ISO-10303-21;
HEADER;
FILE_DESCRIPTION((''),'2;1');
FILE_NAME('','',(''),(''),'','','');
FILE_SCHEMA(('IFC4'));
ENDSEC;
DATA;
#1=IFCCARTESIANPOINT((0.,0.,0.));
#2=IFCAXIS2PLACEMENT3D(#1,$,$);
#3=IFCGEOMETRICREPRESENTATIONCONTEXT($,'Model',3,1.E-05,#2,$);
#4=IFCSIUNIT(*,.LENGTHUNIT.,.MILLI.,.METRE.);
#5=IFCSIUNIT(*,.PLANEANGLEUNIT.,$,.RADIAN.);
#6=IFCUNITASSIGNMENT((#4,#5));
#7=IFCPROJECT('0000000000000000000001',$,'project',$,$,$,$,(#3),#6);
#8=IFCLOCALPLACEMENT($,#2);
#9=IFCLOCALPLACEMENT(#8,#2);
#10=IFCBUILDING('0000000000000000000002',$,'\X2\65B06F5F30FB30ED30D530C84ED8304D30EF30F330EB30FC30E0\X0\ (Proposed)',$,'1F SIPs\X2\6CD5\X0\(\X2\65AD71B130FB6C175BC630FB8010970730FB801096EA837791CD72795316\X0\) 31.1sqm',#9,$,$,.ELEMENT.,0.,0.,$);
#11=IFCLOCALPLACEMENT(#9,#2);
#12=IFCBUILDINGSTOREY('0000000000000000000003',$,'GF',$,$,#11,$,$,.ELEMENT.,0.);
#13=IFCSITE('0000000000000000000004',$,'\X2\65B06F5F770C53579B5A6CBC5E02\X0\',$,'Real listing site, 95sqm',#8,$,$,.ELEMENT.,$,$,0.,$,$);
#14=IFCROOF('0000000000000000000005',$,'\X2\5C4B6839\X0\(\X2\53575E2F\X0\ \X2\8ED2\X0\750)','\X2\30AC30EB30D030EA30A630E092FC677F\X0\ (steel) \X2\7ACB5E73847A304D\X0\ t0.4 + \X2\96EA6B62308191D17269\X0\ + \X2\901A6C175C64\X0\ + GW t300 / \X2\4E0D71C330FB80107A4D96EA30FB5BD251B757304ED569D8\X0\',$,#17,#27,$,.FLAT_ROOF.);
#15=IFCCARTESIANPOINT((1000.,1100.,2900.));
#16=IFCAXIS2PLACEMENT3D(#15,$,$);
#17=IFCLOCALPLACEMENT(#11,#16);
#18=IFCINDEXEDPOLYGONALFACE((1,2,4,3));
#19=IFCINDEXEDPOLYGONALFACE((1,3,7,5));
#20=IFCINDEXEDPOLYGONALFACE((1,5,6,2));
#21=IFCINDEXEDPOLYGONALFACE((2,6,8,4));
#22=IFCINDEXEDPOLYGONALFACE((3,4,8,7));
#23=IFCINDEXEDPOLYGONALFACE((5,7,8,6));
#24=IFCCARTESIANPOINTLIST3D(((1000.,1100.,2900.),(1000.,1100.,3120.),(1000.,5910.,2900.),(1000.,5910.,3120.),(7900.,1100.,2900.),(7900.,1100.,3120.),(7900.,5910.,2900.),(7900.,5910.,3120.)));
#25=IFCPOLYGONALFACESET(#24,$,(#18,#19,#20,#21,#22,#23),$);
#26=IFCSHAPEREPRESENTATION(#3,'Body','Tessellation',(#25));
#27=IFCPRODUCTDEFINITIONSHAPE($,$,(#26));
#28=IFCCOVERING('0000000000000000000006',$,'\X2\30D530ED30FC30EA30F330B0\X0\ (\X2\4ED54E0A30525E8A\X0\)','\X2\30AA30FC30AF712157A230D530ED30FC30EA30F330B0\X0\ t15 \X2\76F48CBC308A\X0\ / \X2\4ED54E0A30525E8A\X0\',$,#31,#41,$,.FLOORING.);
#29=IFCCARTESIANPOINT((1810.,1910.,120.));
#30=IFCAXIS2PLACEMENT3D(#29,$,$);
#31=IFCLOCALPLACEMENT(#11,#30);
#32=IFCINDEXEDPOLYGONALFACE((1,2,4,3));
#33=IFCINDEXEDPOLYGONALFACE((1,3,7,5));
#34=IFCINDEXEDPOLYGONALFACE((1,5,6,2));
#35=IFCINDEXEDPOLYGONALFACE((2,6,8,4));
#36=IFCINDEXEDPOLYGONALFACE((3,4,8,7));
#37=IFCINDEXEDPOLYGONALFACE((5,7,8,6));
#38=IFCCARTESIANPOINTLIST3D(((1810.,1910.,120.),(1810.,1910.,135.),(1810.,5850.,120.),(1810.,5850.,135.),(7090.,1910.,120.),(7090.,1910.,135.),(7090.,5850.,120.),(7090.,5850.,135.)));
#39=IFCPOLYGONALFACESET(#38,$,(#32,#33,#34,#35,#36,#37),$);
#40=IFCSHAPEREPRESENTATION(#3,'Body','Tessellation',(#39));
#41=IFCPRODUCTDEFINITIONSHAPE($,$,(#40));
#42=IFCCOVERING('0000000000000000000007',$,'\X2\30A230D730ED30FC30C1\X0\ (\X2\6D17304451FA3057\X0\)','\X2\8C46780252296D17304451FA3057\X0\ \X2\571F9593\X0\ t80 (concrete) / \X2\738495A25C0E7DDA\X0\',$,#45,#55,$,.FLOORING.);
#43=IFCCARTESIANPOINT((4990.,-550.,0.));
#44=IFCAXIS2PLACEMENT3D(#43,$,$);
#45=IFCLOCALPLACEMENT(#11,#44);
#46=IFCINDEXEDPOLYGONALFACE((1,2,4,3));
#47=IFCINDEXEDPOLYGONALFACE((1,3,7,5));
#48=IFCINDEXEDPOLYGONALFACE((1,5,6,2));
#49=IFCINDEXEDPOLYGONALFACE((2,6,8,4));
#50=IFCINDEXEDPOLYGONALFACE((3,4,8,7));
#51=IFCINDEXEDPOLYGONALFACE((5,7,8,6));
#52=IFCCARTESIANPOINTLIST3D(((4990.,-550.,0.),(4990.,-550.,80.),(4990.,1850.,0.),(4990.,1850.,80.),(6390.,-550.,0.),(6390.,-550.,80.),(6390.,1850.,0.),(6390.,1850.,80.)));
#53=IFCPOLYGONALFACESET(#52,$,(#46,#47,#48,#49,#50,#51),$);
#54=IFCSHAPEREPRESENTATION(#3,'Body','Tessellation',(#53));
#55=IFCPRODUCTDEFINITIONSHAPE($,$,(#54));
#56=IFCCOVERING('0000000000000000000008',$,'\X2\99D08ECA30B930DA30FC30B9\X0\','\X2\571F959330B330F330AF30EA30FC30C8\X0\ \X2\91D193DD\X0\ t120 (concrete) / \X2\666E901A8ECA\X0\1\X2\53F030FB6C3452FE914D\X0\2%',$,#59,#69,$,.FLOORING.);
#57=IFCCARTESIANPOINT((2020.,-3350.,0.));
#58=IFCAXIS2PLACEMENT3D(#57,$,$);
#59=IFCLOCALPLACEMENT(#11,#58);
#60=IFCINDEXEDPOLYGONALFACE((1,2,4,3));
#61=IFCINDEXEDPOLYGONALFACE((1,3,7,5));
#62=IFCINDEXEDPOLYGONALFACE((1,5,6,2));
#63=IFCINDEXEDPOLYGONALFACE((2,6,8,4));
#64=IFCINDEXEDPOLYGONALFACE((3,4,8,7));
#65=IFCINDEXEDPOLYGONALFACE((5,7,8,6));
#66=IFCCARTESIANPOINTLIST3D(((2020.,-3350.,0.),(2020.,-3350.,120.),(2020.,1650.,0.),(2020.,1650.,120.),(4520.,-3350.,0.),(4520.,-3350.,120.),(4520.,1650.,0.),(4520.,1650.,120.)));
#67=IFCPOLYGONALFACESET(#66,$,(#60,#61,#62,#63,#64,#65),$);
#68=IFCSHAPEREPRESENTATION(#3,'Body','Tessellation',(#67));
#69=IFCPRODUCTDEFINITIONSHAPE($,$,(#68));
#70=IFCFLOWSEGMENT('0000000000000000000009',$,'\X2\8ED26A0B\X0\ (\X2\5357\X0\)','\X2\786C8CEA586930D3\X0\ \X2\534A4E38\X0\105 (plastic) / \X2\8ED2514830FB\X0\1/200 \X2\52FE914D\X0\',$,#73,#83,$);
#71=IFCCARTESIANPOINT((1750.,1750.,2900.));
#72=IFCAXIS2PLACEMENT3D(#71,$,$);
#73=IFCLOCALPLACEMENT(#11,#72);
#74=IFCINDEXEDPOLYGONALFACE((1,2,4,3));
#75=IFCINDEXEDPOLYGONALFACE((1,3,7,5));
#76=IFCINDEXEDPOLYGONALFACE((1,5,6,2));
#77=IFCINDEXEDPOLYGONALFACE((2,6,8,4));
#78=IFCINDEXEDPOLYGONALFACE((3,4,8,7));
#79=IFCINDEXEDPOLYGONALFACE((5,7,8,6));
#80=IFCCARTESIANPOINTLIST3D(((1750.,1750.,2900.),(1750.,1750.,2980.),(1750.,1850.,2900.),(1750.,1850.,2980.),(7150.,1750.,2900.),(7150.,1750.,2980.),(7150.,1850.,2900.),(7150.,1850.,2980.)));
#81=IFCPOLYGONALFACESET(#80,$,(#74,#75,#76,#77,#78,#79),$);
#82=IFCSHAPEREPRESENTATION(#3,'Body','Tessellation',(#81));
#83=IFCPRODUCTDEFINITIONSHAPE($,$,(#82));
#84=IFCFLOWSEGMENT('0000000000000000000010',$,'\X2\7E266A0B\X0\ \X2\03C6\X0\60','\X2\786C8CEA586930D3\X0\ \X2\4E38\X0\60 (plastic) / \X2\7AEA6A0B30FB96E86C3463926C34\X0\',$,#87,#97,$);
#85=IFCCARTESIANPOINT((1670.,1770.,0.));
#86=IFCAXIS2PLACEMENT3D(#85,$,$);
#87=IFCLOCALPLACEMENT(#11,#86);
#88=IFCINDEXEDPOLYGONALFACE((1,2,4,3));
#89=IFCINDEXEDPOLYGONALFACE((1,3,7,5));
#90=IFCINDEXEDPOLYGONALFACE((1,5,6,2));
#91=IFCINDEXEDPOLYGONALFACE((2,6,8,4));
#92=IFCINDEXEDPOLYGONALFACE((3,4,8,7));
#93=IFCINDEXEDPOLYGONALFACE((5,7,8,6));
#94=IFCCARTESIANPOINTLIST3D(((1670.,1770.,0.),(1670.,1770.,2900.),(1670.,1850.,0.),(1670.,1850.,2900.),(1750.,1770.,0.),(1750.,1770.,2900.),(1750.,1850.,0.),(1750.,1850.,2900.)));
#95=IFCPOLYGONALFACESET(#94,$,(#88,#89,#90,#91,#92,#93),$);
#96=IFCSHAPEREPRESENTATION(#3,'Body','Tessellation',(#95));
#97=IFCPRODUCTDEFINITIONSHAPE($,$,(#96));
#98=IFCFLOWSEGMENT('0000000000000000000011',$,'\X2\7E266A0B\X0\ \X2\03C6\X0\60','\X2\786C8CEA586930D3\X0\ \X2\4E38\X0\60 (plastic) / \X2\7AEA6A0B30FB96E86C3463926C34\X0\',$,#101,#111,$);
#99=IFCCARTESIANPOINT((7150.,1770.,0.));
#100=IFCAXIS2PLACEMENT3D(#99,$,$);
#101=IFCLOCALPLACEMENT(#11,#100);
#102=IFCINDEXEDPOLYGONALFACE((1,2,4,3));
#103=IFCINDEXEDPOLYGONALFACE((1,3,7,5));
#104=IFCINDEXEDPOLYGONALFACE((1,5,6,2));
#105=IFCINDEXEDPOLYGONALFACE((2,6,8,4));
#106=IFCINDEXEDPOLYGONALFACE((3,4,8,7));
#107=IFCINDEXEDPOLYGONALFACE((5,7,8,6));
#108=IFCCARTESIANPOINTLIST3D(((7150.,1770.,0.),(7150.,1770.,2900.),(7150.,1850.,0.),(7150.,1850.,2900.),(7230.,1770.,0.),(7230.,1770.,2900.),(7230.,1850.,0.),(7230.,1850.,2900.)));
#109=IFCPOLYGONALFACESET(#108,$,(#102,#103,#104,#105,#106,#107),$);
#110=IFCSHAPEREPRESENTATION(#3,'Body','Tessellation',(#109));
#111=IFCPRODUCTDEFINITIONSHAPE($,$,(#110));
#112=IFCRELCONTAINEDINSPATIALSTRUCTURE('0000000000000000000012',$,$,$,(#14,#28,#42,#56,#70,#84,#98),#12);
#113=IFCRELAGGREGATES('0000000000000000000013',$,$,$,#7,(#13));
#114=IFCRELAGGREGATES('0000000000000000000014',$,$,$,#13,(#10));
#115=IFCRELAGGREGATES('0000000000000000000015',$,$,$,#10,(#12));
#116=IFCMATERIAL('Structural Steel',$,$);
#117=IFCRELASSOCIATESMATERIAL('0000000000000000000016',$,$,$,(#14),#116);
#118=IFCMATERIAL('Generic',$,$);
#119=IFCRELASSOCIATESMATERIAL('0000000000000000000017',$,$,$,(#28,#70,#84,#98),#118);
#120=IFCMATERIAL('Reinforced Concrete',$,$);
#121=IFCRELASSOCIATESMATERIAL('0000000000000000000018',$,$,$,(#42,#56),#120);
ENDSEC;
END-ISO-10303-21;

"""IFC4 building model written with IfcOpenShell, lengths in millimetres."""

from ifc_helpers import new_model, si_unit, frame, frame_2d, origin, place, context, project, spatial, rectangle, extrude, material, element, save


model = new_model("IFC4")

# Units and contexts
model_context = context("Model", 3, precision=1e-05, world=origin())
ifc_project = project(units=[si_unit("LENGTHUNIT", "METRE", prefix="MILLI"), si_unit("PLANEANGLEUNIT", "RADIAN")], contexts=[model_context])

# Site, building, storey
site_placement = place(None, origin())
site = spatial("IfcSite", under=ifc_project, at=site_placement, Name="新潟県南魚沼市", ObjectType="Real listing site, 95sqm", CompositionType="ELEMENT", RefElevation=0.0)
building_placement = place(site_placement, origin())
building = spatial("IfcBuilding", under=site, at=building_placement, Name="新潟・ロフト付きワンルーム (Proposed)", ObjectType="1F SIPs法(断熱・気密・耐震・耐雪荷重特化) 31.1sqm", CompositionType="ELEMENT", ElevationOfRefHeight=0.0, ElevationOfTerrain=0.0)
storey_placement = place(building_placement, origin())
storey = spatial("IfcBuildingStorey", under=building, at=storey_placement, Name="GF", CompositionType="ELEMENT", Elevation=0.0)

# Shared definitions
ifc_material_1 = material(Name="Reinforced Concrete")

# Roof
ifc_material_2 = material(Name="Structural Steel")
roof_placement = place(storey_placement, frame((1000.0, 1100.0, 2900.0)))
element("IfcRoof", 1, at=roof_placement, inside=storey, material=ifc_material_2, Name="屋根(南帯 軒750)", Description="ガルバリウム鋼板 (steel) 立平葺き t0.4 + 雪止め金物 + 通気層 + GW t300 / 不燃・耐積雪・寒冷地仕様", PredefinedType="FLAT_ROOF", context=model_context, shape_type="SweptSolid", body=[
    extrude(rectangle(XDim=6900.0, YDim=4810.0, at=frame_2d((3450.0, 2405.0))), frame((1000.0, 1100.0, 2900.0)), (0.0, 0.0, 1.0), 220.0),
])

# Coverings
ifc_material_3 = material(Name="Generic")
covering_1_placement = place(storey_placement, frame((1810.0, 1910.0, 120.0)))
element("IfcCovering", 2, at=covering_1_placement, inside=storey, material=ifc_material_3, Name="フローリング (仕上げ床)", Description="オーク無垢フローリング t15 直貼り / 仕上げ床", PredefinedType="FLOORING", context=model_context, shape_type="SweptSolid", body=[
    extrude(rectangle(XDim=5280.0, YDim=3940.0, at=frame_2d((2640.0, 1970.0))), frame((1810.0, 1910.0, 120.0)), (0.0, 0.0, 1.0), 15.0),
])
covering_2_placement = place(storey_placement, frame((4990.0, -550.0, 0.0)))
element("IfcCovering", 3, at=covering_2_placement, inside=storey, material=ifc_material_1, Name="アプローチ (洗い出し)", Description="豆砂利洗い出し 土間 t80 (concrete) / 玄関導線", PredefinedType="FLOORING", context=model_context, shape_type="SweptSolid", body=[
    extrude(rectangle(XDim=1400.0, YDim=2400.0, at=frame_2d((700.0, 1200.0))), frame((4990.0, -550.0, 0.0)), (0.0, 0.0, 1.0), 80.0),
])
covering_3_placement = place(storey_placement, frame((2020.0, -3350.0, 0.0)))
element("IfcCovering", 4, at=covering_3_placement, inside=storey, material=ifc_material_1, Name="駐車スペース", Description="土間コンクリート 金鏝 t120 (concrete) / 普通車1台・水勾配2%", PredefinedType="FLOORING", context=model_context, shape_type="SweptSolid", body=[
    extrude(rectangle(XDim=2500.0, YDim=5000.0, at=frame_2d((1250.0, 2500.0))), frame((2020.0, -3350.0, 0.0)), (0.0, 0.0, 1.0), 120.0),
])

# Flow segments
flow_segment_1_placement = place(storey_placement, frame((1750.0, 1750.0, 2900.0)))
element("IfcFlowSegment", 5, at=flow_segment_1_placement, inside=storey, material=ifc_material_3, Name="軒樋 (南)", Description="硬質塩ビ 半丸105 (plastic) / 軒先・1/200 勾配", context=model_context, shape_type="SweptSolid", body=[
    extrude(rectangle(XDim=5400.0, YDim=100.0, at=frame_2d((2700.0, 50.0))), frame((1750.0, 1750.0, 2900.0)), (0.0, 0.0, 1.0), 80.0),
])
flow_segment_2_placement = place(storey_placement, frame((1670.0, 1770.0, 0.0)))
element("IfcFlowSegment", 6, at=flow_segment_2_placement, inside=storey, material=ifc_material_3, Name="縦樋 φ60", Description="硬質塩ビ 丸60 (plastic) / 竪樋・雨水排水", context=model_context, shape_type="SweptSolid", body=[
    extrude(rectangle(XDim=80.0, YDim=80.0, at=frame_2d((40.0, 40.0))), frame((1670.0, 1770.0, 0.0)), (0.0, 0.0, 1.0), 2900.0),
])
flow_segment_3_placement = place(storey_placement, frame((7150.0, 1770.0, 0.0)))
element("IfcFlowSegment", 7, at=flow_segment_3_placement, inside=storey, material=ifc_material_3, Name="縦樋 φ60", Description="硬質塩ビ 丸60 (plastic) / 竪樋・雨水排水", context=model_context, shape_type="SweptSolid", body=[
    extrude(rectangle(XDim=80.0, YDim=80.0, at=frame_2d((40.0, 40.0))), frame((7150.0, 1770.0, 0.0)), (0.0, 0.0, 1.0), 2900.0),
])

save(model, "model.ifc")
